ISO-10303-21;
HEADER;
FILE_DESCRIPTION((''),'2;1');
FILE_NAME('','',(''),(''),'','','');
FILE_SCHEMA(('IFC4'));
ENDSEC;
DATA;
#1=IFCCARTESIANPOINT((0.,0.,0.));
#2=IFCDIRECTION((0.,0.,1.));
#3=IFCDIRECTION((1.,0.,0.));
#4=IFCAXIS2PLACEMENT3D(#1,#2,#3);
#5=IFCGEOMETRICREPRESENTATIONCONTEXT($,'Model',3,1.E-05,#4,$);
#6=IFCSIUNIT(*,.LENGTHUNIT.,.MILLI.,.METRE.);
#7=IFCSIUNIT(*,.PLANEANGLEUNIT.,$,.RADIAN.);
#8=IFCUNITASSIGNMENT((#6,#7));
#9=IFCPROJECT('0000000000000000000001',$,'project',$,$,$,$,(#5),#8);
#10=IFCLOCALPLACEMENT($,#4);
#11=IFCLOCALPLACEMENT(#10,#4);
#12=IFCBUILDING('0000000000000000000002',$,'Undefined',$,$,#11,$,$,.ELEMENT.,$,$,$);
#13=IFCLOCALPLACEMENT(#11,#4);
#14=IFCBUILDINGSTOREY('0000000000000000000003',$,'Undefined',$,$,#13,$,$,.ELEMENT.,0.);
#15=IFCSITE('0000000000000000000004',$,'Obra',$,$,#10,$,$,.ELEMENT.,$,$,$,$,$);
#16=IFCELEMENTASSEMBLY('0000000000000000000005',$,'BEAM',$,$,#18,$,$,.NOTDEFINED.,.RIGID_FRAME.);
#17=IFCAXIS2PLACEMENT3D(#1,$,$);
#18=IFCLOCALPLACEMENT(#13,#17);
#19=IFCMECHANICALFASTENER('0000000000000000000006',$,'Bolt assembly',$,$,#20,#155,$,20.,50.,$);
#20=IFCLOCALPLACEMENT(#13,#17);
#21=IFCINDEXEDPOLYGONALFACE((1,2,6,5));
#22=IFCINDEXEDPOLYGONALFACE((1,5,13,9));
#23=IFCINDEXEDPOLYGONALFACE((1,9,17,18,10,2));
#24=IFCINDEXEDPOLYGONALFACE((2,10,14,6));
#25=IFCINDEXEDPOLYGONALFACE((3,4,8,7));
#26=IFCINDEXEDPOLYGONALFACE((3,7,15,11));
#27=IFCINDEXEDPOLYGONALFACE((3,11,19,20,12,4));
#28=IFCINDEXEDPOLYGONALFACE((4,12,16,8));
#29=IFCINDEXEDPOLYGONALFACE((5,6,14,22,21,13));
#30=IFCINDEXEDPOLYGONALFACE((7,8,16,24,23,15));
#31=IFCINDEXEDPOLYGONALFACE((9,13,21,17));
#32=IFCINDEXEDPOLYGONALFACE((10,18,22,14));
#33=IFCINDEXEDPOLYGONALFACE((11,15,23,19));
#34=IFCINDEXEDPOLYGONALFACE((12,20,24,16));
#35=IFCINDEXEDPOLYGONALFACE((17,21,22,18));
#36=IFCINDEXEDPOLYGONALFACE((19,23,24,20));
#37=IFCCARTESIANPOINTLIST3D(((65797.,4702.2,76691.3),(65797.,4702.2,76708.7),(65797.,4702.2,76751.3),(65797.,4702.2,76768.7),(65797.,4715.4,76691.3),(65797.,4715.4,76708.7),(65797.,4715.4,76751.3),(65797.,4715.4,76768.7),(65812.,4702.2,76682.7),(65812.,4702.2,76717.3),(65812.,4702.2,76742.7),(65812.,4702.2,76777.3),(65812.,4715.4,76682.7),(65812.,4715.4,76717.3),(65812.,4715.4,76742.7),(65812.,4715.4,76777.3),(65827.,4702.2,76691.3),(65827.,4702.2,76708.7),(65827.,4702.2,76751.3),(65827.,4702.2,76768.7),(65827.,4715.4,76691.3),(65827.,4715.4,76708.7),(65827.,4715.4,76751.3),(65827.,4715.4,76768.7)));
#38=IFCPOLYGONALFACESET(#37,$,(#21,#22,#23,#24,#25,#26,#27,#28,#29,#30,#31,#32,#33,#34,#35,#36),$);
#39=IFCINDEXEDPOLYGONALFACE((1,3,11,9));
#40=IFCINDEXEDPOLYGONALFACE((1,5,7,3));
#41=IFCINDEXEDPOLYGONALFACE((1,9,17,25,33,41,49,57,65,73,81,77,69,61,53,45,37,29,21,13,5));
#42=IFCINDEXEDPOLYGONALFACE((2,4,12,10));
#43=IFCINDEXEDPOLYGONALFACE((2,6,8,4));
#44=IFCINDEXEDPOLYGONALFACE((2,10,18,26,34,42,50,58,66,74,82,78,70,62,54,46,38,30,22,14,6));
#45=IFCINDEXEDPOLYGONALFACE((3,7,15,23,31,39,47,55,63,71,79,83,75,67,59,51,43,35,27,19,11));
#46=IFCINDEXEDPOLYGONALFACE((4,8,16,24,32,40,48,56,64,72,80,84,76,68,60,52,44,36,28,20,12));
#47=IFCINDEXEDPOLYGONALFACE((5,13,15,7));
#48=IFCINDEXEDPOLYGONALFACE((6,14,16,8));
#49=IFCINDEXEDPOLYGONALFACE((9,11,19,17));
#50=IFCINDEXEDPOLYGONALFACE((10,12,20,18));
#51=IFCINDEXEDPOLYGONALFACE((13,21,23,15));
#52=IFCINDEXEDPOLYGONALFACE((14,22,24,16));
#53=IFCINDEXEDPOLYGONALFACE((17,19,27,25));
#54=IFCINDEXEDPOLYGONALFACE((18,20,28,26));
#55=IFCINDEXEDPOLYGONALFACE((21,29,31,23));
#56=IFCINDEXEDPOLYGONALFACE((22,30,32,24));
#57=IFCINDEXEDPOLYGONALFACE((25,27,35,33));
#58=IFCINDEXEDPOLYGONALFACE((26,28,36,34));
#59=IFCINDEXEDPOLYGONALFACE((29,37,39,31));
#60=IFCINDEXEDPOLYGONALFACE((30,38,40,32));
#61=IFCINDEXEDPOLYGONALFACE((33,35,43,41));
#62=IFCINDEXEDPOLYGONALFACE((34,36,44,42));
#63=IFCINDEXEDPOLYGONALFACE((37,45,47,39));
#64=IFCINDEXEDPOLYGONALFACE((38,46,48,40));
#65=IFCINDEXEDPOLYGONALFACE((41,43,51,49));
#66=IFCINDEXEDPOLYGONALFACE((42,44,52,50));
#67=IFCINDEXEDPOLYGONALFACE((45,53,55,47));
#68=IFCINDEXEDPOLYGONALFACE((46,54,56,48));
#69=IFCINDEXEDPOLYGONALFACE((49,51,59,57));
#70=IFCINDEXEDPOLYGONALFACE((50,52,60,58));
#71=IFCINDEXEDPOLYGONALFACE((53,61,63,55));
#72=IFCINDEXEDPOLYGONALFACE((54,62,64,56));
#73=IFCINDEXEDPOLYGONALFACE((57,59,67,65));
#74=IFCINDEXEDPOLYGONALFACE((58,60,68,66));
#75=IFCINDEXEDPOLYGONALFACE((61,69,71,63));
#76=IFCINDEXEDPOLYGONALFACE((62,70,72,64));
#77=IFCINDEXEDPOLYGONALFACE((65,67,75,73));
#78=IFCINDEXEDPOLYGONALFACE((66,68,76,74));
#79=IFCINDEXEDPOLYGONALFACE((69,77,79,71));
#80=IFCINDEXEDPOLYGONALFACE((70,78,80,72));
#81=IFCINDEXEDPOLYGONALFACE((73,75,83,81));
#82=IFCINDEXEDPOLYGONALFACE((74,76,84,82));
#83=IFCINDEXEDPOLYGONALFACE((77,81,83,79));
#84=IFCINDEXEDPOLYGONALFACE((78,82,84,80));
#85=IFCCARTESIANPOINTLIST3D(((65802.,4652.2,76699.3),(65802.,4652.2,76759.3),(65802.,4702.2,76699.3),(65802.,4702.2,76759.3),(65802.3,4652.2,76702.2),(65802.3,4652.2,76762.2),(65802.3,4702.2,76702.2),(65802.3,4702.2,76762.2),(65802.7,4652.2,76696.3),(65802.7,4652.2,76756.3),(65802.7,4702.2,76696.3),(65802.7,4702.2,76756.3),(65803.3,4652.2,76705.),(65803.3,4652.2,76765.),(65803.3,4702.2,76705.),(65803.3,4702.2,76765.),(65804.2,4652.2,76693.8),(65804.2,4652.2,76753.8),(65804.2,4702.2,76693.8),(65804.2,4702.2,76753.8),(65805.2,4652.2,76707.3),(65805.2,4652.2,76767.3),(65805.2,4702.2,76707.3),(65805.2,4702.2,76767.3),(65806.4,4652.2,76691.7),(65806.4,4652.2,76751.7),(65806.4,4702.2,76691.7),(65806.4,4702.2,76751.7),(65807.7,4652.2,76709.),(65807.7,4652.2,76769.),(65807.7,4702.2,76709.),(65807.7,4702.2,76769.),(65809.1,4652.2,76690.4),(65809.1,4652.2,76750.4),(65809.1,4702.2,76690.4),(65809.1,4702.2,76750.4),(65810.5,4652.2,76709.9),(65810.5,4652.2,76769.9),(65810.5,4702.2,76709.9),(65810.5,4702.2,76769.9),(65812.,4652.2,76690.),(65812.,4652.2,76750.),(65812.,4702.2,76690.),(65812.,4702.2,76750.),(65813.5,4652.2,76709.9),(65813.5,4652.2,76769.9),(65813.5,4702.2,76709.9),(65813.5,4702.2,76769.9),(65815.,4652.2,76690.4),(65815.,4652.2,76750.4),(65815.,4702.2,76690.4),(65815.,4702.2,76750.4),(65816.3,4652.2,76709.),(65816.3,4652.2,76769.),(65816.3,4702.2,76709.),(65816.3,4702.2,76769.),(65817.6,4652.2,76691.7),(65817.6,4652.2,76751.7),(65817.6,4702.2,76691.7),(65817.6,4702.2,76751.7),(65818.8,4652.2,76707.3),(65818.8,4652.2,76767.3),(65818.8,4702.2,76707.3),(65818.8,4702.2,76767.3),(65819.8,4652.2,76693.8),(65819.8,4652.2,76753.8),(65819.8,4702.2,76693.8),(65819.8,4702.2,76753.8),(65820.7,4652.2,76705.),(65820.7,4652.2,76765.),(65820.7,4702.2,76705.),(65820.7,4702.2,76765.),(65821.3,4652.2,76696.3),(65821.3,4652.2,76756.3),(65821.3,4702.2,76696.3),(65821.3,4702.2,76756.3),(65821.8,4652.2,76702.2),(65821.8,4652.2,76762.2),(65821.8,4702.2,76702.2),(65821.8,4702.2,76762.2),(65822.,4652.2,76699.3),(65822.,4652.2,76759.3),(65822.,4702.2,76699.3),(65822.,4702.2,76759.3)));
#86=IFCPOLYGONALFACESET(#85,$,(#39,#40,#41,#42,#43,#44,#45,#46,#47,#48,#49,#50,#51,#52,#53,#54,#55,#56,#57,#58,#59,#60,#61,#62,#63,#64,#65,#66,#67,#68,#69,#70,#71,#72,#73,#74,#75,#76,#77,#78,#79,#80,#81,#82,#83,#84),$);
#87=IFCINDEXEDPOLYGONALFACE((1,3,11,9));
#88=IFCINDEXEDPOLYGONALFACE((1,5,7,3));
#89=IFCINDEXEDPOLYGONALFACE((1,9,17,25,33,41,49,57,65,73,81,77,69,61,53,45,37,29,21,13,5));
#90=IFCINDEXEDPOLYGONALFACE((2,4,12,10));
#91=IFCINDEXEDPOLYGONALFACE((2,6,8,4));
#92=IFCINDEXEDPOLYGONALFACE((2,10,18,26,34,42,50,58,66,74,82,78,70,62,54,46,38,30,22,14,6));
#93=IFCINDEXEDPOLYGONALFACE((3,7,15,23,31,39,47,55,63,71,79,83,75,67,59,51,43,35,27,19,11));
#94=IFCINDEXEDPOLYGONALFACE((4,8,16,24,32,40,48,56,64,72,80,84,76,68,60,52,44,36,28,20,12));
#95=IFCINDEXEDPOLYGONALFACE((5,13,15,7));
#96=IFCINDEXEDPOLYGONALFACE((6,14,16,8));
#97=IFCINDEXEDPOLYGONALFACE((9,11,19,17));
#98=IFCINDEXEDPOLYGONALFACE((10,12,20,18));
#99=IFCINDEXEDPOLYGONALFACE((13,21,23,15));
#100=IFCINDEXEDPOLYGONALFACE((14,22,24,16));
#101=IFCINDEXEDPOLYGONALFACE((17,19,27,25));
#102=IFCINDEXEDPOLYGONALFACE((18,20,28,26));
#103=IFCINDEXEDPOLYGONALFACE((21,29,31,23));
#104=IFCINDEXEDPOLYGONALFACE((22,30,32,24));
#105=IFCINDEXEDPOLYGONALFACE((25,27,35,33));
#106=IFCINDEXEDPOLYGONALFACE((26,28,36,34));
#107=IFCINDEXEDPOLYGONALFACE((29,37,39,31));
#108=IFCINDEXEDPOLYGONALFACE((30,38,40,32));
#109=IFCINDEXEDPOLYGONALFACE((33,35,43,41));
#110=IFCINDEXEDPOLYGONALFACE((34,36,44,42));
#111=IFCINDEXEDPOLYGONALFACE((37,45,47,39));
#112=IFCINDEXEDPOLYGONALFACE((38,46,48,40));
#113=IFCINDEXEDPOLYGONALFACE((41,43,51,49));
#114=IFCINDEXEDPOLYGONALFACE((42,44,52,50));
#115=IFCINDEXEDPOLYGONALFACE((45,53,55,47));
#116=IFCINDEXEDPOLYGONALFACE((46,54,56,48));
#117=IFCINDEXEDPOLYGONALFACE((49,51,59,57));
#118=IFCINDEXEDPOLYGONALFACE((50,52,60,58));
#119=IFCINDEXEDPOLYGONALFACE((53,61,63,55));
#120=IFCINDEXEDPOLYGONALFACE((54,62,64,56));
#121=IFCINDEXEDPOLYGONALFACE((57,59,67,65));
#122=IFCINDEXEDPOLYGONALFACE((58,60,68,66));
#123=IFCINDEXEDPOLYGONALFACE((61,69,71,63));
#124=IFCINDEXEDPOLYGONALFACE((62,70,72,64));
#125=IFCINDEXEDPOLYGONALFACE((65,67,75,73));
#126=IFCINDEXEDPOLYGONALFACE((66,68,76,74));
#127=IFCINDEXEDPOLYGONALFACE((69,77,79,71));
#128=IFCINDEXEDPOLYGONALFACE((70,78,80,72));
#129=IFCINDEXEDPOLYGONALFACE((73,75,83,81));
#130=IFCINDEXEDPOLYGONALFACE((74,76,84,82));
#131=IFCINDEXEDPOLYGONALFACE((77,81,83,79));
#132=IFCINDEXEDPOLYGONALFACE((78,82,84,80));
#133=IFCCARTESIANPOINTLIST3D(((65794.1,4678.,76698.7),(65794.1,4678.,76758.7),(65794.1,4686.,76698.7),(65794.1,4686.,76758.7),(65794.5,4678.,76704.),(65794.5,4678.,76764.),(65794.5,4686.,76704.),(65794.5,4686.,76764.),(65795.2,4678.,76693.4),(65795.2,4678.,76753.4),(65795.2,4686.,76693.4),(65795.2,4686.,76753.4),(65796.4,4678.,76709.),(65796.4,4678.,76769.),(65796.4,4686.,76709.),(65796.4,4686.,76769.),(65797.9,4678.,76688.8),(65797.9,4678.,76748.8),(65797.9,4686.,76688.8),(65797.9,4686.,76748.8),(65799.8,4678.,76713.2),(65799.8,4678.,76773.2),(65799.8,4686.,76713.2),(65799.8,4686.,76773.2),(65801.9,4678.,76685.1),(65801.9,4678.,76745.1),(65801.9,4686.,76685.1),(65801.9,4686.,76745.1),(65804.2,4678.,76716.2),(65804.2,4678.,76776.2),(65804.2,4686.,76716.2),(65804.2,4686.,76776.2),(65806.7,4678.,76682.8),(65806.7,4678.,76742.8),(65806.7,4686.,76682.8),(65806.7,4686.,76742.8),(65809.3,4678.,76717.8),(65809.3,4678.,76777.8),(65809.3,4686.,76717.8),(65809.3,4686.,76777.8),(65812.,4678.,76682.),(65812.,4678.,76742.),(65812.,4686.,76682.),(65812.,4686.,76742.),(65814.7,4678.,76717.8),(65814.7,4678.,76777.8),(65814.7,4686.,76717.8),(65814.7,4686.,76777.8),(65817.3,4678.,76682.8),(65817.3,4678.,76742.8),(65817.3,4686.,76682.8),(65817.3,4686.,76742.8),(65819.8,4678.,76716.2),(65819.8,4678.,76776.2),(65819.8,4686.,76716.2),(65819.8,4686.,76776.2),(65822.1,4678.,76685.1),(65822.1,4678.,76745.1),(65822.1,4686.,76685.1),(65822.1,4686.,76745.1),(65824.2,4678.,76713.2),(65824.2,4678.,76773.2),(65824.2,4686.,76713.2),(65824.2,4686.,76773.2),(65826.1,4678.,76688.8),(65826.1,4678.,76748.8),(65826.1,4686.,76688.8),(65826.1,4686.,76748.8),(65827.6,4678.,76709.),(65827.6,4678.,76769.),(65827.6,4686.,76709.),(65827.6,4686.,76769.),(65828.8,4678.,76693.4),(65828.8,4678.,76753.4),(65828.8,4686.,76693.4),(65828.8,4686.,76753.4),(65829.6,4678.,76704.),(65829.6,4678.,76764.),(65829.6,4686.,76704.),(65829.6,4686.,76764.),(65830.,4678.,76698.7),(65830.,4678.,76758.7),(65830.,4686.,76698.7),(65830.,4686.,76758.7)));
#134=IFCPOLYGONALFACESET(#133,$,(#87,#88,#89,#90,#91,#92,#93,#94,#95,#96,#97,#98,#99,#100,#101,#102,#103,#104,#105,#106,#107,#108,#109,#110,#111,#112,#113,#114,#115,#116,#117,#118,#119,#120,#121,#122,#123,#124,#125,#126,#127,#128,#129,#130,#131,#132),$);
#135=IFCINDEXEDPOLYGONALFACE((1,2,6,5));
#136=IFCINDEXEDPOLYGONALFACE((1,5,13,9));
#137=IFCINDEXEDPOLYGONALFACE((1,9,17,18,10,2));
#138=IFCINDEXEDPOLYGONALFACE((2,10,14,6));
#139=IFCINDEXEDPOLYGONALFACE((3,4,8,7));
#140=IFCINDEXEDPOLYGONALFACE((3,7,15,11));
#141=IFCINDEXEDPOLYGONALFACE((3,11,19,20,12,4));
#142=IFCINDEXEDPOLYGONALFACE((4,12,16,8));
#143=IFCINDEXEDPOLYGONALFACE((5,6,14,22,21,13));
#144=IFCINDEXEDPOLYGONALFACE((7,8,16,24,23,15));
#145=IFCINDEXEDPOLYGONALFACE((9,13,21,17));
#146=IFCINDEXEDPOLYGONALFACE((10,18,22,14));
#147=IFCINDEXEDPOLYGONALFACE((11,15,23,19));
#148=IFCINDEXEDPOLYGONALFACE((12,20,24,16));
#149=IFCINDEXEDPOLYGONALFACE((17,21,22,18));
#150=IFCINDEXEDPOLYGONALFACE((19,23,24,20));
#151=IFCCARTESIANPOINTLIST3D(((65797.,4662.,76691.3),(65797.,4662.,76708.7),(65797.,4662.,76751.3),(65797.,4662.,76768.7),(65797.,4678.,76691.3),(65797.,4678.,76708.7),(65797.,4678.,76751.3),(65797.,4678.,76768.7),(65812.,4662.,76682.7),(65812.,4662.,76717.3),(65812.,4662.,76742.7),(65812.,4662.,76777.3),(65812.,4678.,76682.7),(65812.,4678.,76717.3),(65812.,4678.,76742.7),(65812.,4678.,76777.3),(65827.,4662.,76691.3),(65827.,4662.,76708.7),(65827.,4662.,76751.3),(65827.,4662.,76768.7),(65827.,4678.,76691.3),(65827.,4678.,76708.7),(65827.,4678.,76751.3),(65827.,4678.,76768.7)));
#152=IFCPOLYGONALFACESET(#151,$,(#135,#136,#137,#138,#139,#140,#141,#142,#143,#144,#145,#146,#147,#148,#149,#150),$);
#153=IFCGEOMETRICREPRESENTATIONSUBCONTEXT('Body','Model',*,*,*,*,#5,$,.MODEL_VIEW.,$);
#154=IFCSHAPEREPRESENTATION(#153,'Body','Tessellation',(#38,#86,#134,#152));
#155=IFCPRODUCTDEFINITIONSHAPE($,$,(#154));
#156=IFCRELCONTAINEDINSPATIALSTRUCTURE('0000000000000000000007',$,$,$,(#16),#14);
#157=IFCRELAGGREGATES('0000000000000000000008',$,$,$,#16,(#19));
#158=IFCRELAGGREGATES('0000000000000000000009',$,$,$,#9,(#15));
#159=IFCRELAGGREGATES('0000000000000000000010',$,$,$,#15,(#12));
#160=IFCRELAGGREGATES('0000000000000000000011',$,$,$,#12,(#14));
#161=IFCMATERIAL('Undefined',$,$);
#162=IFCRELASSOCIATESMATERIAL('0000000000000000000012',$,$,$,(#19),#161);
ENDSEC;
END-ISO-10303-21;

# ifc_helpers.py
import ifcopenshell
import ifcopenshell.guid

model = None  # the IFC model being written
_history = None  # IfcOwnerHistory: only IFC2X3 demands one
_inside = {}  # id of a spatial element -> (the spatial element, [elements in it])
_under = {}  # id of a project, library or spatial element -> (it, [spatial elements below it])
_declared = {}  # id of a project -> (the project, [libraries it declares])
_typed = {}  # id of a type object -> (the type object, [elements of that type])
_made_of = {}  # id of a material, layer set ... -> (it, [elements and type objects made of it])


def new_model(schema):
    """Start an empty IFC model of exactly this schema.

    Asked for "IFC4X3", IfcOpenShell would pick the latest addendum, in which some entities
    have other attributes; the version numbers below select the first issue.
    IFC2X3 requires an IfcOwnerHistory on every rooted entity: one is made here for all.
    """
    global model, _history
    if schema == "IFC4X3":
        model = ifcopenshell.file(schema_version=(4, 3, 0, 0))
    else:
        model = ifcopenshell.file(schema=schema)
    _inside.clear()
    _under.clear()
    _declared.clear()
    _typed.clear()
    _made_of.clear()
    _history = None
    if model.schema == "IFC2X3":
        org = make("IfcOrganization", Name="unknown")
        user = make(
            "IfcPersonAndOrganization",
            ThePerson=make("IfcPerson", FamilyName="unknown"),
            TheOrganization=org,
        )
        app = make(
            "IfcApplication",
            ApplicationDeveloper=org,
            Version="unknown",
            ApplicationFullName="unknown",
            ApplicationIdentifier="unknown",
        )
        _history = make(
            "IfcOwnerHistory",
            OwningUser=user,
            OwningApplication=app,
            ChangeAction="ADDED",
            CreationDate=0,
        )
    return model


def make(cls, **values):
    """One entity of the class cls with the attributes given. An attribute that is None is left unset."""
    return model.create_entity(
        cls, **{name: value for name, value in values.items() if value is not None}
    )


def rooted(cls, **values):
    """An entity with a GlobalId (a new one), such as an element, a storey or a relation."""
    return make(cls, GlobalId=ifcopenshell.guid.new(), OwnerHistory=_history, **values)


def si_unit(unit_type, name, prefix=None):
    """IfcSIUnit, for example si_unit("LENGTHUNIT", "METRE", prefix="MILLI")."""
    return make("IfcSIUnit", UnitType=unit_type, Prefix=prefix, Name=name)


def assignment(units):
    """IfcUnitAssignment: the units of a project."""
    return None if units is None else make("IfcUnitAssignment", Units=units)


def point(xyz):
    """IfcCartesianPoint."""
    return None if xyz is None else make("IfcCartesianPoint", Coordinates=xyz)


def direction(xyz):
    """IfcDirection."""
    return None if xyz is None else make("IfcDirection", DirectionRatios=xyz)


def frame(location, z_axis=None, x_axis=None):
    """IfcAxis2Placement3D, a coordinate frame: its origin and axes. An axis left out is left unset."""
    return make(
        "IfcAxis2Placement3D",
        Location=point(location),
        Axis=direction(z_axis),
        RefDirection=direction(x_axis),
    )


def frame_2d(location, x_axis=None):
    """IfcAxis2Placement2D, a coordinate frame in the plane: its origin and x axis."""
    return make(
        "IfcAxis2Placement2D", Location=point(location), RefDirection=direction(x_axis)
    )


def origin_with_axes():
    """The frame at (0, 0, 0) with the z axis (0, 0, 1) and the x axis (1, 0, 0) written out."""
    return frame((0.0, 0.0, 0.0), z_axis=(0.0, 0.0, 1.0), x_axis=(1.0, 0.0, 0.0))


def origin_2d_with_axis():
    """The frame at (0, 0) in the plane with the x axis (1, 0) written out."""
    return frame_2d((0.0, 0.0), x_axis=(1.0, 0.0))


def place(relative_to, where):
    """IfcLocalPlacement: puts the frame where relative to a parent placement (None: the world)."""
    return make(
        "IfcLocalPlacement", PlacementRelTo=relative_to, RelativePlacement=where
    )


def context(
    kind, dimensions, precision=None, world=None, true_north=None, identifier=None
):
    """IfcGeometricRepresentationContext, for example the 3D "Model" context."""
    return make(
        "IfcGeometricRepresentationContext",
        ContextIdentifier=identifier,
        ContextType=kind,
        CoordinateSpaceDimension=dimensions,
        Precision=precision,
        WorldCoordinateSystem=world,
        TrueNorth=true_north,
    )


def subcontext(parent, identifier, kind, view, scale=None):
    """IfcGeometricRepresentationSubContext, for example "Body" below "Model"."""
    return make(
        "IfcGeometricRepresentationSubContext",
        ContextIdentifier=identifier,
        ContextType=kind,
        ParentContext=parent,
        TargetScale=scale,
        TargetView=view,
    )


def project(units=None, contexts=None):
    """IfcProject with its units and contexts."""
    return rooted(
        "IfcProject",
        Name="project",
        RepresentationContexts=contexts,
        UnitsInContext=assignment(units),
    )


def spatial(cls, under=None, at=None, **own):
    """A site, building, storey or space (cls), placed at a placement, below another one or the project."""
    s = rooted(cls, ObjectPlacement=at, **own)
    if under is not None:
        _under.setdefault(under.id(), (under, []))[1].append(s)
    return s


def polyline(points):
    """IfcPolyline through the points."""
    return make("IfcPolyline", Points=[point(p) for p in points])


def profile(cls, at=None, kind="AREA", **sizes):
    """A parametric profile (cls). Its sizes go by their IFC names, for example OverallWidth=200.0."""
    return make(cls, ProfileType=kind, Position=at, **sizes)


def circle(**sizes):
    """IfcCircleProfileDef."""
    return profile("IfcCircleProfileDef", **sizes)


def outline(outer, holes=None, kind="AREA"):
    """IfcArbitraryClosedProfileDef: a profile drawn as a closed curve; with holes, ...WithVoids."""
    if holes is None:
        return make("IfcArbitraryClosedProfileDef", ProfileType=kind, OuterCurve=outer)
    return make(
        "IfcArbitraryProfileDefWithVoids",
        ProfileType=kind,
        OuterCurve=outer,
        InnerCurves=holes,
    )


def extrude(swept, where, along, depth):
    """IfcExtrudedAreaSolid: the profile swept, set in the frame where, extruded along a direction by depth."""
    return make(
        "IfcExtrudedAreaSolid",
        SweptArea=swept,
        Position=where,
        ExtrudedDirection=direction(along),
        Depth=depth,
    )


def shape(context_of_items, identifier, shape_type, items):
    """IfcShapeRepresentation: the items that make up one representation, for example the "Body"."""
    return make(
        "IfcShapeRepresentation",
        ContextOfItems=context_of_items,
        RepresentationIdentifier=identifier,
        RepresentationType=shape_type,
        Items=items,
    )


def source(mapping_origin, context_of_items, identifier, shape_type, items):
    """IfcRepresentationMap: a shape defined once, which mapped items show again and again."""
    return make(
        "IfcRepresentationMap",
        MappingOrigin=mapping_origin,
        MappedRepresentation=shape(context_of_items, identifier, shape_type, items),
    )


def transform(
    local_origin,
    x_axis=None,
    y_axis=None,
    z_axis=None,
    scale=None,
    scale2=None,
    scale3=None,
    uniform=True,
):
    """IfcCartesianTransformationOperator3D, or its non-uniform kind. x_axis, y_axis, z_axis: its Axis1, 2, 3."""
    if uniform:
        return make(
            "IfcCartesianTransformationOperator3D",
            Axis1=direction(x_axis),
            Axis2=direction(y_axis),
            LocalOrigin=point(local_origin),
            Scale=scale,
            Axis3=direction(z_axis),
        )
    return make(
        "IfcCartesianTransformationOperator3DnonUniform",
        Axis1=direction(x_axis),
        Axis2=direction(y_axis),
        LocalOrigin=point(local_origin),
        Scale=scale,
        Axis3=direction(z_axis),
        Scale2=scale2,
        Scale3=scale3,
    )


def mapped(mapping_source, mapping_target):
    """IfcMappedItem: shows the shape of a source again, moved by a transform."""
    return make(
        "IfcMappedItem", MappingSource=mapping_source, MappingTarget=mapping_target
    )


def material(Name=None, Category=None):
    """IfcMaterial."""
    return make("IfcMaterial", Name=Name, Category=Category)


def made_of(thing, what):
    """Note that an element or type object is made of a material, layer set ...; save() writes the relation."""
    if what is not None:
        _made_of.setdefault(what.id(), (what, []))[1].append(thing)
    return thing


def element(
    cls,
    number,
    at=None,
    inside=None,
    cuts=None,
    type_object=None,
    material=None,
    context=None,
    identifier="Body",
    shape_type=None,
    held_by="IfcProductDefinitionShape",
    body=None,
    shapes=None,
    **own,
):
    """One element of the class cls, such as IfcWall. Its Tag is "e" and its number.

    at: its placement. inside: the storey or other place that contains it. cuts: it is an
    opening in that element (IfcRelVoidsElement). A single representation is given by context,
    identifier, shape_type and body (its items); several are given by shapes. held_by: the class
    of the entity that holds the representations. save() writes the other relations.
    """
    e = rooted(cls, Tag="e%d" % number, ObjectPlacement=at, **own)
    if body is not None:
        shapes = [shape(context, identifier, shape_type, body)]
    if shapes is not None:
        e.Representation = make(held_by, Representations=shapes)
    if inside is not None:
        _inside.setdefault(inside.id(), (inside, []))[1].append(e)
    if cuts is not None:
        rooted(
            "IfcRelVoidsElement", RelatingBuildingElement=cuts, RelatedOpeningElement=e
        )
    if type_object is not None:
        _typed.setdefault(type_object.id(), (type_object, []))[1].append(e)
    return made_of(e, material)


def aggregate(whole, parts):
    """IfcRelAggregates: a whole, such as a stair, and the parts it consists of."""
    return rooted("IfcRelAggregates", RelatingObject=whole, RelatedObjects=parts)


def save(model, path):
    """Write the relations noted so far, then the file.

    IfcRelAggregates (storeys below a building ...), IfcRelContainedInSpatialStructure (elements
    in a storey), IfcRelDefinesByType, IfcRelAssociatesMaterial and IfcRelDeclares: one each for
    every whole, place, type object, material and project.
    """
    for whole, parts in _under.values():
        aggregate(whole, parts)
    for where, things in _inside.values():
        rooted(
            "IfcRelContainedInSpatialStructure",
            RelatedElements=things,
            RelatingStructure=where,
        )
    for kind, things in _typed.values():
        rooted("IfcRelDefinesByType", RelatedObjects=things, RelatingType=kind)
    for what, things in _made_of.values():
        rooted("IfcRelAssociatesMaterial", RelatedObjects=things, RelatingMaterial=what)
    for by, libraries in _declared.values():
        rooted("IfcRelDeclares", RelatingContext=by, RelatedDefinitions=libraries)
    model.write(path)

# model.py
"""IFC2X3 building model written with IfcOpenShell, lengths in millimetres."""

from ifc_helpers import new_model, si_unit, frame, origin_with_axes, origin_2d_with_axis, place, context, subcontext, project, spatial, polyline, circle, outline, extrude, source, transform, mapped, material, element, aggregate, save


model = new_model("IFC2X3")

# Units and contexts
model_context = context("Model", 3, precision=1e-05, world=origin_with_axes())
body_context = subcontext(model_context, "Body", "Model", "MODEL_VIEW")
ifc_project = project(units=[si_unit("LENGTHUNIT", "METRE", prefix="MILLI"), si_unit("PLANEANGLEUNIT", "RADIAN")], contexts=[model_context])

# Site, building, storey
site_placement = place(None, origin_with_axes())
site = spatial("IfcSite", under=ifc_project, at=site_placement, Name="Obra", CompositionType="ELEMENT")
building_placement = place(site_placement, origin_with_axes())
building = spatial("IfcBuilding", under=site, at=building_placement, Name="Undefined", CompositionType="ELEMENT")
storey_placement = place(building_placement, origin_with_axes())
storey = spatial("IfcBuildingStorey", under=building, at=storey_placement, Name="Undefined", CompositionType="ELEMENT", Elevation=0.0)

# Element assembly
assembly_1_placement = place(storey_placement, origin_with_axes())
assembly_1 = element("IfcElementAssembly", 1, at=assembly_1_placement, inside=storey, Name="BEAM", AssemblyPlace="NOTDEFINED", PredefinedType="RIGID_FRAME")

# Mechanical fastener
ifc_material_1 = material(Name="Undefined")
shared_shape_1 = source(origin_with_axes(), body_context, "Body", "SweptSolid", [
    extrude(outline(polyline([(17.3, 0.0), (8.7, 15.0), (-8.7, 15.0), (-17.3, 0.0), (-8.7, -15.0), (8.7, -15.0), (17.3, 0.0)])), frame((0.0, -26.3, 0.0), z_axis=(0.0, 1.0, 0.0), x_axis=(1.0, 0.0, 0.0)), (0.0, 0.0, 1.0), 13.2),
    extrude(circle(Radius=10.0, at=origin_2d_with_axis()), frame((0.0, -13.1, 0.0), z_axis=(0.0, 1.0, 0.0), x_axis=(1.0, 0.0, 0.0)), (0.0, 0.0, 1.0), 50.0),
    extrude(circle(Radius=18.0, at=origin_2d_with_axis()), frame((0.0, 3.1, 0.0), z_axis=(0.0, 1.0, 0.0), x_axis=(1.0, 0.0, 0.0)), (0.0, 0.0, 1.0), 8.0),
    extrude(outline(polyline([(17.3, 0.0), (8.7, 15.0), (-8.7, 15.0), (-17.3, 0.0), (-8.7, -15.0), (8.7, -15.0), (17.3, 0.0)])), frame((0.0, 11.1, 0.0), z_axis=(0.0, 1.0, 0.0), x_axis=(1.0, 0.0, 0.0)), (0.0, 0.0, 1.0), 16.0),
])
mechanical_fastener_1_placement = place(assembly_1_placement, frame((65852.0, 4689.1, 76850.0), z_axis=(-1.0, 0.0, 0.0), x_axis=(0.0, 0.0, -1.0)))
mechanical_fastener_1 = element("IfcMechanicalFastener", 2, at=mechanical_fastener_1_placement, material=ifc_material_1, Name="Bolt assembly", NominalDiameter=20.0, NominalLength=50.0, context=body_context, shape_type="MappedRepresentation", body=[
    mapped(shared_shape_1, transform((90.0, 0.0, 40.0))),
    mapped(shared_shape_1, transform((150.0, 0.0, 40.0))),
])
aggregate(assembly_1, [mechanical_fastener_1])

save(model, "model.ifc")
